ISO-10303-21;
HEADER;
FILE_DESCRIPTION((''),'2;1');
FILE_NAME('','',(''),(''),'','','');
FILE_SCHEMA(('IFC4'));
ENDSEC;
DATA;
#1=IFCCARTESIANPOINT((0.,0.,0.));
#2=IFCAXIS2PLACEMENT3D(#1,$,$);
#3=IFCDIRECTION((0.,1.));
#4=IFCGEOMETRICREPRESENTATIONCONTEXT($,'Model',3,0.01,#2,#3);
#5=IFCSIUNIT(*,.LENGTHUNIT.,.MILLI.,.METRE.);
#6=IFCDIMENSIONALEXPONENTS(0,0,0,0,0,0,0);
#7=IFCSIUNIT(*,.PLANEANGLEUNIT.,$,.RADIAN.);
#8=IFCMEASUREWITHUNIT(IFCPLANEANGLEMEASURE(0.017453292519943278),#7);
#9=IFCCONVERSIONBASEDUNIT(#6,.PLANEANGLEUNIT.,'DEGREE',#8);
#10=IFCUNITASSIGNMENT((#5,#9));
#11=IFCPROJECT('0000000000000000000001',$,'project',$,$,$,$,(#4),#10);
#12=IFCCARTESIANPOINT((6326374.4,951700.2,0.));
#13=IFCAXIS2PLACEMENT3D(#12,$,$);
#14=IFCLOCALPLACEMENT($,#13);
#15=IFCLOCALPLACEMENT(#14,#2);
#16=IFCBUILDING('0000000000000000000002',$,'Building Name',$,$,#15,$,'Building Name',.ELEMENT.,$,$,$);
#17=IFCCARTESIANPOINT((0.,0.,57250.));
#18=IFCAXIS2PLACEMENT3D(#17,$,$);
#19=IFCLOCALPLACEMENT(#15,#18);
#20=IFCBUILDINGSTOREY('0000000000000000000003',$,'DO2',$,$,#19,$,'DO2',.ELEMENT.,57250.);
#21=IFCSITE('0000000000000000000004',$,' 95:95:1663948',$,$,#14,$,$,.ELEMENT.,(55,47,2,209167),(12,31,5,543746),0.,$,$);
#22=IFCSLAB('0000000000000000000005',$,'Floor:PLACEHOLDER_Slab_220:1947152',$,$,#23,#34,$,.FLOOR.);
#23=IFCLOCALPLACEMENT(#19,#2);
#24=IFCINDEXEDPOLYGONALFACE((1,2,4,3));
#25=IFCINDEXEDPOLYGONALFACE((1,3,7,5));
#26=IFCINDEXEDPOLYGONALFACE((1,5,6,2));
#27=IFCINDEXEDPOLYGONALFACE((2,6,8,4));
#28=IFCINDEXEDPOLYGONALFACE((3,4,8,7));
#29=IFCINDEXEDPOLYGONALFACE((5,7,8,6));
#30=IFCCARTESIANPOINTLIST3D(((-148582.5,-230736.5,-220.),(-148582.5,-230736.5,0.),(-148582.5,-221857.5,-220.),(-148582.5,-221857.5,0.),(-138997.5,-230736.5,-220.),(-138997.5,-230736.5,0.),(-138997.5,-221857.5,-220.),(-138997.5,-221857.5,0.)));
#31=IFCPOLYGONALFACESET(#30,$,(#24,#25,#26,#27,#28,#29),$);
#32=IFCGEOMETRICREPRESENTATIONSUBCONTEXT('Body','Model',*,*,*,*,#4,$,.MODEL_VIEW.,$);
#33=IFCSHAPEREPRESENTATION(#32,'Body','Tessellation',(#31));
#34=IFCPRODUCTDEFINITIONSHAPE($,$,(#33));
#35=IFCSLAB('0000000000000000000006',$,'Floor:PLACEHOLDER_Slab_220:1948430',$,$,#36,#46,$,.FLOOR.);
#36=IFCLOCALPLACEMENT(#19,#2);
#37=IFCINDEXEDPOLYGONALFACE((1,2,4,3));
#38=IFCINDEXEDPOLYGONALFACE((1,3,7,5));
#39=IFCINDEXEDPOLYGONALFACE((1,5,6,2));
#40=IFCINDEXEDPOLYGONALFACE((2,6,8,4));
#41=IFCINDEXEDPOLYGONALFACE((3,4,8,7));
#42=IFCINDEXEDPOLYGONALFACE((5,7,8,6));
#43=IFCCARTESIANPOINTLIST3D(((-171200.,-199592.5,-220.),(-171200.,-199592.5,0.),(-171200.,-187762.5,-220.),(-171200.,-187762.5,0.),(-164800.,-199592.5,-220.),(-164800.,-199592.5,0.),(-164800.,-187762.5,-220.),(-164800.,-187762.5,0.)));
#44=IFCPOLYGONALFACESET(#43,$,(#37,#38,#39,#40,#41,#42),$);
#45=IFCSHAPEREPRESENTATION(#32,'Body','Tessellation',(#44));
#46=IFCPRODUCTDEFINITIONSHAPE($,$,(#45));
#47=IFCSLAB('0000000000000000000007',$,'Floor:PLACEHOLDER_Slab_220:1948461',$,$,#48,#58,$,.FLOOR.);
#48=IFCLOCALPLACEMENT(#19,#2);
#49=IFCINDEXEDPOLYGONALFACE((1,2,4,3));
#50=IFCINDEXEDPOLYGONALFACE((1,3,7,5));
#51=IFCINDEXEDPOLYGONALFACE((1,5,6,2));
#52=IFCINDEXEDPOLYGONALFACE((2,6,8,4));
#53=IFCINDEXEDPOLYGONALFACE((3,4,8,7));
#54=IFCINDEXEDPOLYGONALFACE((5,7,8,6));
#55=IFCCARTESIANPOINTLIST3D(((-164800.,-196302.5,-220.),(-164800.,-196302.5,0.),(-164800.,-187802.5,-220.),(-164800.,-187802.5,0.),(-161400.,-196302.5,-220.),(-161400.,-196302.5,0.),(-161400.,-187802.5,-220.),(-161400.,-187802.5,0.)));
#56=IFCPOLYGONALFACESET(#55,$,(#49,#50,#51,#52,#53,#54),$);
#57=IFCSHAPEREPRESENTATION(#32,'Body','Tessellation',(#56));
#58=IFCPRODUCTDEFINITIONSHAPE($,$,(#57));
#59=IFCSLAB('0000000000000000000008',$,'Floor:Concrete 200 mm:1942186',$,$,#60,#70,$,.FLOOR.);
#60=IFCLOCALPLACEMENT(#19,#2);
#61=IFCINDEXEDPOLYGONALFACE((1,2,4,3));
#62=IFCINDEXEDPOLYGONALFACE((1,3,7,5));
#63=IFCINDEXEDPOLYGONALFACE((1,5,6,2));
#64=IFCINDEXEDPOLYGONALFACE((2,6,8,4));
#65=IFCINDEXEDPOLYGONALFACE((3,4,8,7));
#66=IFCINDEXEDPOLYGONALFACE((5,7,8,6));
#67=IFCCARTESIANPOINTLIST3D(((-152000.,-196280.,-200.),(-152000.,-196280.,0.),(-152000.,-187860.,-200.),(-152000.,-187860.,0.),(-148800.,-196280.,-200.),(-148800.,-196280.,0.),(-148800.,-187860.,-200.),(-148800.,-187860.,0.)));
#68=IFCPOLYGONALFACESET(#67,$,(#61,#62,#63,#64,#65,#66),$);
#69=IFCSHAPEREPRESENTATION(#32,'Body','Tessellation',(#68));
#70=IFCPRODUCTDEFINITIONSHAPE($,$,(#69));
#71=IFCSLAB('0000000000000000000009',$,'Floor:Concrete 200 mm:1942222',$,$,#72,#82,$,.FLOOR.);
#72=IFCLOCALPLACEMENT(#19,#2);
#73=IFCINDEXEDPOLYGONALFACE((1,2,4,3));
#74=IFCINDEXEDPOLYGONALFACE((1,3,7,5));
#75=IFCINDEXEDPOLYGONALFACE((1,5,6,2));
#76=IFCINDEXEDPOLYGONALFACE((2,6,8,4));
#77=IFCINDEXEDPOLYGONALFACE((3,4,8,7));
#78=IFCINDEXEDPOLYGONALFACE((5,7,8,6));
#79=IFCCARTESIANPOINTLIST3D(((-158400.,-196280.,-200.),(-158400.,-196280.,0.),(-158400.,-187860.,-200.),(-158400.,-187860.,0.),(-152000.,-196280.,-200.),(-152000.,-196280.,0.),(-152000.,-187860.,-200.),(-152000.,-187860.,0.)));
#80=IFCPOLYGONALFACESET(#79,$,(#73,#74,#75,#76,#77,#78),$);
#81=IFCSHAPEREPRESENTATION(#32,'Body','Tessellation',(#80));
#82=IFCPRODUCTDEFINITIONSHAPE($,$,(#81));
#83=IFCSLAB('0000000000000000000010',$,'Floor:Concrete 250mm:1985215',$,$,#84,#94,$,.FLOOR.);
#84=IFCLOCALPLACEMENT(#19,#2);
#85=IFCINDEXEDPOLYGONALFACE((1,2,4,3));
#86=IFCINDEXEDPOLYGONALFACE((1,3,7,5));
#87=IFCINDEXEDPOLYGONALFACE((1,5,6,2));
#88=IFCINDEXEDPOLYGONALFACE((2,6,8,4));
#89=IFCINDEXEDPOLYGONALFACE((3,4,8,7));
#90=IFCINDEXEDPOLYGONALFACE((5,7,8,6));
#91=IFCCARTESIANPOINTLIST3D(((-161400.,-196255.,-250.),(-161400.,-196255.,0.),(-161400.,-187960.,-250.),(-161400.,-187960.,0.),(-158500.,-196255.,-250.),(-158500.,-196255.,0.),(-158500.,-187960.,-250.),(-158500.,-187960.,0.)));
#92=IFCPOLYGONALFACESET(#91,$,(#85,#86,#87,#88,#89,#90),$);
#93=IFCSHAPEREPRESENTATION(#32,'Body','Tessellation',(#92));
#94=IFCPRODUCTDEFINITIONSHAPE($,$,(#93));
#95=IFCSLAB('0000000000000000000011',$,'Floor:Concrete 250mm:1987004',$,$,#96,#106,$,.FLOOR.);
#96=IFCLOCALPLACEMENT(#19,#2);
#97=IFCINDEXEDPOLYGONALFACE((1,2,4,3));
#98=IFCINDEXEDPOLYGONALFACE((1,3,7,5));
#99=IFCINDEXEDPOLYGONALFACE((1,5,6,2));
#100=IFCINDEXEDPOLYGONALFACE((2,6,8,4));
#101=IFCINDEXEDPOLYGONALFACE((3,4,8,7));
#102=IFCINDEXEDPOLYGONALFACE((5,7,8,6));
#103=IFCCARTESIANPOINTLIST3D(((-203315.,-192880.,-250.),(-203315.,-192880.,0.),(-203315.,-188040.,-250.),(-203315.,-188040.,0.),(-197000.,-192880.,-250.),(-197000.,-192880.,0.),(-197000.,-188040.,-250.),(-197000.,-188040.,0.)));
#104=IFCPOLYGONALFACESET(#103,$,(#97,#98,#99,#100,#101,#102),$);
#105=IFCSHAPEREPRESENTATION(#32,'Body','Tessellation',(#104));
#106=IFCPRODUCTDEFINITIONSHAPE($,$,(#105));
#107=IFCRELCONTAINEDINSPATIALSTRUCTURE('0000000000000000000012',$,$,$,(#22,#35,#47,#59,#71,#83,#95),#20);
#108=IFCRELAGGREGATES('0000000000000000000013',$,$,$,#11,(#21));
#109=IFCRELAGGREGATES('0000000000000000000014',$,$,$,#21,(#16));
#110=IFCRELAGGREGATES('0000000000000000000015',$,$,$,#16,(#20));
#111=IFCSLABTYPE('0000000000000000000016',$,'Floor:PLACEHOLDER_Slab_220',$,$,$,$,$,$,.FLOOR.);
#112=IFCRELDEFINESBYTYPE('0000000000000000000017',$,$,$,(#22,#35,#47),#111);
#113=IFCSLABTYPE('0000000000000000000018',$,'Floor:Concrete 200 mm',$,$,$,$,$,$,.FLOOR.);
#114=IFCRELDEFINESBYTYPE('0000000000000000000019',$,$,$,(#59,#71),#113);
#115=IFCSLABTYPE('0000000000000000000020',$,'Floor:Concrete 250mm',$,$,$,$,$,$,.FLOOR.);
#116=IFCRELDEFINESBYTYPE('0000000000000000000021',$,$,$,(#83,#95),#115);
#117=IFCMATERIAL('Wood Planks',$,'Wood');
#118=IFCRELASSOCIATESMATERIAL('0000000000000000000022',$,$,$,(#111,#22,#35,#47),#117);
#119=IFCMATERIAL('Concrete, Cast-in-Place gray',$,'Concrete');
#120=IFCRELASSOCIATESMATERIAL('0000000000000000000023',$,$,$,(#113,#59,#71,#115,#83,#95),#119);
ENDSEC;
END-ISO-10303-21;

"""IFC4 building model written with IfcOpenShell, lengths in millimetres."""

from ifc_helpers import new_model, entity, si_unit, converted_unit, direction, frame, origin, place, context, subcontext, project, spatial, indexed_curve, outline, extrude, material, type_object, element, save


model = new_model("IFC4")

# Units and contexts
model_context = context("Model", 3, precision=0.01, world=origin(), true_north=direction((0.0, 1.0)))
body_context = subcontext(model_context, "Body", "Model", "MODEL_VIEW")
ifc_project = project(units=[si_unit("LENGTHUNIT", "METRE", prefix="MILLI"), converted_unit("PLANEANGLEUNIT", "DEGREE", entity("IfcPlaneAngleMeasure", 0.017453292519943278), si_unit("PLANEANGLEUNIT", "RADIAN"), dimensions=[0, 0, 0, 0, 0, 0, 0])], contexts=[model_context])

# Site, building, storey
site_placement = place(None, frame((6326374.4, 951700.2, 0.0)))
site = spatial("IfcSite", under=ifc_project, at=site_placement, Name=" 95:95:1663948", CompositionType="ELEMENT", RefLatitude=(55, 47, 2, 209167), RefLongitude=(12, 31, 5, 543746), RefElevation=0.0)
building_placement = place(site_placement, origin())
building = spatial("IfcBuilding", under=site, at=building_placement, Name="Building Name", LongName="Building Name", CompositionType="ELEMENT")
storey_placement = place(building_placement, frame((0.0, 0.0, 57250.0)))
storey = spatial("IfcBuildingStorey", under=building, at=storey_placement, Name="DO2", LongName="DO2", CompositionType="ELEMENT", Elevation=57250.0)

# Shared definitions
ifc_material_1 = material(Name="Concrete, Cast-in-Place gray", Category="Concrete")

# Slabs
ifc_material_2 = material(Name="Wood Planks", Category="Wood")
slab_type_1 = type_object("IfcSlabType", Name="Floor:PLACEHOLDER_Slab_220", PredefinedType="FLOOR", material=ifc_material_2)
slab_1_placement = place(storey_placement, origin())
element("IfcSlab", 1, at=slab_1_placement, inside=storey, type_object=slab_type_1, material=ifc_material_2, Name="Floor:PLACEHOLDER_Slab_220:1947152", PredefinedType="FLOOR", context=body_context, shape_type="SweptSolid", body=[
    extrude(outline(indexed_curve([(-4439.5, -4792.5), (4439.5, -4792.5), (4439.5, 4792.5), (-4439.5, 4792.5), (-4439.5, -4792.5)], self_intersect=False)), frame((-143790.0, -226297.0, 0.0), z_axis=(0.0, 0.0, -1.0), x_axis=(0.0, 1.0, 0.0)), (0.0, 0.0, 1.0), 220.0),
])
slab_2_placement = place(storey_placement, origin())
element("IfcSlab", 2, at=slab_2_placement, inside=storey, type_object=slab_type_1, material=ifc_material_2, Name="Floor:PLACEHOLDER_Slab_220:1948430", PredefinedType="FLOOR", context=body_context, shape_type="SweptSolid", body=[
    extrude(outline(indexed_curve([(-5915.0, -3200.0), (5915.0, -3200.0), (5915.0, 3200.0), (-5915.0, 3200.0), (-5915.0, -3200.0)], self_intersect=False)), frame((-168000.0, -193677.5, 0.0), z_axis=(0.0, 0.0, -1.0), x_axis=(0.0, 1.0, 0.0)), (0.0, 0.0, 1.0), 220.0),
])
slab_3_placement = place(storey_placement, origin())
element("IfcSlab", 3, at=slab_3_placement, inside=storey, type_object=slab_type_1, material=ifc_material_2, Name="Floor:PLACEHOLDER_Slab_220:1948461", PredefinedType="FLOOR", context=body_context, shape_type="SweptSolid", body=[
    extrude(outline(indexed_curve([(-4250.0, -1700.0), (4250.0, -1700.0), (4250.0, 1700.0), (-4250.0, 1700.0), (-4250.0, -1700.0)], self_intersect=False)), frame((-163100.0, -192052.5, 0.0), z_axis=(0.0, 0.0, -1.0), x_axis=(0.0, 1.0, 0.0)), (0.0, 0.0, 1.0), 220.0),
])
slab_type_2 = type_object("IfcSlabType", Name="Floor:Concrete 200 mm", PredefinedType="FLOOR", material=ifc_material_1)
slab_4_placement = place(storey_placement, origin())
element("IfcSlab", 4, at=slab_4_placement, inside=storey, type_object=slab_type_2, material=ifc_material_1, Name="Floor:Concrete 200 mm:1942186", PredefinedType="FLOOR", context=body_context, shape_type="SweptSolid", body=[
    extrude(outline(indexed_curve([(-4210.0, -1600.0), (4210.0, -1600.0), (4210.0, 1600.0), (-4210.0, 1600.0), (-4210.0, -1600.0)], self_intersect=False)), frame((-150400.0, -192070.0, 0.0), z_axis=(0.0, 0.0, -1.0), x_axis=(0.0, 1.0, 0.0)), (0.0, 0.0, 1.0), 200.0),
])
slab_5_placement = place(storey_placement, origin())
element("IfcSlab", 5, at=slab_5_placement, inside=storey, type_object=slab_type_2, material=ifc_material_1, Name="Floor:Concrete 200 mm:1942222", PredefinedType="FLOOR", context=body_context, shape_type="SweptSolid", body=[
    extrude(outline(indexed_curve([(-4210.0, -3200.0), (4210.0, -3200.0), (4210.0, 3200.0), (-4210.0, 3200.0), (-4210.0, -3200.0)], self_intersect=False)), frame((-155200.0, -192070.0, 0.0), z_axis=(0.0, 0.0, -1.0), x_axis=(0.0, 1.0, 0.0)), (0.0, 0.0, 1.0), 200.0),
])
slab_type_3 = type_object("IfcSlabType", Name="Floor:Concrete 250mm", PredefinedType="FLOOR", material=ifc_material_1)
slab_6_placement = place(storey_placement, origin())
element("IfcSlab", 6, at=slab_6_placement, inside=storey, type_object=slab_type_3, material=ifc_material_1, Name="Floor:Concrete 250mm:1985215", PredefinedType="FLOOR", context=body_context, shape_type="SweptSolid", body=[
    extrude(outline(indexed_curve([(-4147.5, -1450.0), (4147.5, -1450.0), (4147.5, 1450.0), (-4147.5, 1450.0), (-4147.5, -1450.0)], self_intersect=False)), frame((-159950.0, -192107.5, 0.0), z_axis=(0.0, 0.0, -1.0), x_axis=(0.0, 1.0, 0.0)), (0.0, 0.0, 1.0), 250.0),
])
slab_7_placement = place(storey_placement, origin())
element("IfcSlab", 7, at=slab_7_placement, inside=storey, type_object=slab_type_3, material=ifc_material_1, Name="Floor:Concrete 250mm:1987004", PredefinedType="FLOOR", context=body_context, shape_type="SweptSolid", body=[
    extrude(outline(indexed_curve([(-2420.0, -3157.5), (2420.0, -3157.5), (2420.0, 3157.5), (-2420.0, 3157.5), (-2420.0, -3157.5)], self_intersect=False)), frame((-200157.5, -190460.0, 0.0), z_axis=(0.0, 0.0, -1.0), x_axis=(0.0, 1.0, 0.0)), (0.0, 0.0, 1.0), 250.0),
])

save(model, "model.ifc")
